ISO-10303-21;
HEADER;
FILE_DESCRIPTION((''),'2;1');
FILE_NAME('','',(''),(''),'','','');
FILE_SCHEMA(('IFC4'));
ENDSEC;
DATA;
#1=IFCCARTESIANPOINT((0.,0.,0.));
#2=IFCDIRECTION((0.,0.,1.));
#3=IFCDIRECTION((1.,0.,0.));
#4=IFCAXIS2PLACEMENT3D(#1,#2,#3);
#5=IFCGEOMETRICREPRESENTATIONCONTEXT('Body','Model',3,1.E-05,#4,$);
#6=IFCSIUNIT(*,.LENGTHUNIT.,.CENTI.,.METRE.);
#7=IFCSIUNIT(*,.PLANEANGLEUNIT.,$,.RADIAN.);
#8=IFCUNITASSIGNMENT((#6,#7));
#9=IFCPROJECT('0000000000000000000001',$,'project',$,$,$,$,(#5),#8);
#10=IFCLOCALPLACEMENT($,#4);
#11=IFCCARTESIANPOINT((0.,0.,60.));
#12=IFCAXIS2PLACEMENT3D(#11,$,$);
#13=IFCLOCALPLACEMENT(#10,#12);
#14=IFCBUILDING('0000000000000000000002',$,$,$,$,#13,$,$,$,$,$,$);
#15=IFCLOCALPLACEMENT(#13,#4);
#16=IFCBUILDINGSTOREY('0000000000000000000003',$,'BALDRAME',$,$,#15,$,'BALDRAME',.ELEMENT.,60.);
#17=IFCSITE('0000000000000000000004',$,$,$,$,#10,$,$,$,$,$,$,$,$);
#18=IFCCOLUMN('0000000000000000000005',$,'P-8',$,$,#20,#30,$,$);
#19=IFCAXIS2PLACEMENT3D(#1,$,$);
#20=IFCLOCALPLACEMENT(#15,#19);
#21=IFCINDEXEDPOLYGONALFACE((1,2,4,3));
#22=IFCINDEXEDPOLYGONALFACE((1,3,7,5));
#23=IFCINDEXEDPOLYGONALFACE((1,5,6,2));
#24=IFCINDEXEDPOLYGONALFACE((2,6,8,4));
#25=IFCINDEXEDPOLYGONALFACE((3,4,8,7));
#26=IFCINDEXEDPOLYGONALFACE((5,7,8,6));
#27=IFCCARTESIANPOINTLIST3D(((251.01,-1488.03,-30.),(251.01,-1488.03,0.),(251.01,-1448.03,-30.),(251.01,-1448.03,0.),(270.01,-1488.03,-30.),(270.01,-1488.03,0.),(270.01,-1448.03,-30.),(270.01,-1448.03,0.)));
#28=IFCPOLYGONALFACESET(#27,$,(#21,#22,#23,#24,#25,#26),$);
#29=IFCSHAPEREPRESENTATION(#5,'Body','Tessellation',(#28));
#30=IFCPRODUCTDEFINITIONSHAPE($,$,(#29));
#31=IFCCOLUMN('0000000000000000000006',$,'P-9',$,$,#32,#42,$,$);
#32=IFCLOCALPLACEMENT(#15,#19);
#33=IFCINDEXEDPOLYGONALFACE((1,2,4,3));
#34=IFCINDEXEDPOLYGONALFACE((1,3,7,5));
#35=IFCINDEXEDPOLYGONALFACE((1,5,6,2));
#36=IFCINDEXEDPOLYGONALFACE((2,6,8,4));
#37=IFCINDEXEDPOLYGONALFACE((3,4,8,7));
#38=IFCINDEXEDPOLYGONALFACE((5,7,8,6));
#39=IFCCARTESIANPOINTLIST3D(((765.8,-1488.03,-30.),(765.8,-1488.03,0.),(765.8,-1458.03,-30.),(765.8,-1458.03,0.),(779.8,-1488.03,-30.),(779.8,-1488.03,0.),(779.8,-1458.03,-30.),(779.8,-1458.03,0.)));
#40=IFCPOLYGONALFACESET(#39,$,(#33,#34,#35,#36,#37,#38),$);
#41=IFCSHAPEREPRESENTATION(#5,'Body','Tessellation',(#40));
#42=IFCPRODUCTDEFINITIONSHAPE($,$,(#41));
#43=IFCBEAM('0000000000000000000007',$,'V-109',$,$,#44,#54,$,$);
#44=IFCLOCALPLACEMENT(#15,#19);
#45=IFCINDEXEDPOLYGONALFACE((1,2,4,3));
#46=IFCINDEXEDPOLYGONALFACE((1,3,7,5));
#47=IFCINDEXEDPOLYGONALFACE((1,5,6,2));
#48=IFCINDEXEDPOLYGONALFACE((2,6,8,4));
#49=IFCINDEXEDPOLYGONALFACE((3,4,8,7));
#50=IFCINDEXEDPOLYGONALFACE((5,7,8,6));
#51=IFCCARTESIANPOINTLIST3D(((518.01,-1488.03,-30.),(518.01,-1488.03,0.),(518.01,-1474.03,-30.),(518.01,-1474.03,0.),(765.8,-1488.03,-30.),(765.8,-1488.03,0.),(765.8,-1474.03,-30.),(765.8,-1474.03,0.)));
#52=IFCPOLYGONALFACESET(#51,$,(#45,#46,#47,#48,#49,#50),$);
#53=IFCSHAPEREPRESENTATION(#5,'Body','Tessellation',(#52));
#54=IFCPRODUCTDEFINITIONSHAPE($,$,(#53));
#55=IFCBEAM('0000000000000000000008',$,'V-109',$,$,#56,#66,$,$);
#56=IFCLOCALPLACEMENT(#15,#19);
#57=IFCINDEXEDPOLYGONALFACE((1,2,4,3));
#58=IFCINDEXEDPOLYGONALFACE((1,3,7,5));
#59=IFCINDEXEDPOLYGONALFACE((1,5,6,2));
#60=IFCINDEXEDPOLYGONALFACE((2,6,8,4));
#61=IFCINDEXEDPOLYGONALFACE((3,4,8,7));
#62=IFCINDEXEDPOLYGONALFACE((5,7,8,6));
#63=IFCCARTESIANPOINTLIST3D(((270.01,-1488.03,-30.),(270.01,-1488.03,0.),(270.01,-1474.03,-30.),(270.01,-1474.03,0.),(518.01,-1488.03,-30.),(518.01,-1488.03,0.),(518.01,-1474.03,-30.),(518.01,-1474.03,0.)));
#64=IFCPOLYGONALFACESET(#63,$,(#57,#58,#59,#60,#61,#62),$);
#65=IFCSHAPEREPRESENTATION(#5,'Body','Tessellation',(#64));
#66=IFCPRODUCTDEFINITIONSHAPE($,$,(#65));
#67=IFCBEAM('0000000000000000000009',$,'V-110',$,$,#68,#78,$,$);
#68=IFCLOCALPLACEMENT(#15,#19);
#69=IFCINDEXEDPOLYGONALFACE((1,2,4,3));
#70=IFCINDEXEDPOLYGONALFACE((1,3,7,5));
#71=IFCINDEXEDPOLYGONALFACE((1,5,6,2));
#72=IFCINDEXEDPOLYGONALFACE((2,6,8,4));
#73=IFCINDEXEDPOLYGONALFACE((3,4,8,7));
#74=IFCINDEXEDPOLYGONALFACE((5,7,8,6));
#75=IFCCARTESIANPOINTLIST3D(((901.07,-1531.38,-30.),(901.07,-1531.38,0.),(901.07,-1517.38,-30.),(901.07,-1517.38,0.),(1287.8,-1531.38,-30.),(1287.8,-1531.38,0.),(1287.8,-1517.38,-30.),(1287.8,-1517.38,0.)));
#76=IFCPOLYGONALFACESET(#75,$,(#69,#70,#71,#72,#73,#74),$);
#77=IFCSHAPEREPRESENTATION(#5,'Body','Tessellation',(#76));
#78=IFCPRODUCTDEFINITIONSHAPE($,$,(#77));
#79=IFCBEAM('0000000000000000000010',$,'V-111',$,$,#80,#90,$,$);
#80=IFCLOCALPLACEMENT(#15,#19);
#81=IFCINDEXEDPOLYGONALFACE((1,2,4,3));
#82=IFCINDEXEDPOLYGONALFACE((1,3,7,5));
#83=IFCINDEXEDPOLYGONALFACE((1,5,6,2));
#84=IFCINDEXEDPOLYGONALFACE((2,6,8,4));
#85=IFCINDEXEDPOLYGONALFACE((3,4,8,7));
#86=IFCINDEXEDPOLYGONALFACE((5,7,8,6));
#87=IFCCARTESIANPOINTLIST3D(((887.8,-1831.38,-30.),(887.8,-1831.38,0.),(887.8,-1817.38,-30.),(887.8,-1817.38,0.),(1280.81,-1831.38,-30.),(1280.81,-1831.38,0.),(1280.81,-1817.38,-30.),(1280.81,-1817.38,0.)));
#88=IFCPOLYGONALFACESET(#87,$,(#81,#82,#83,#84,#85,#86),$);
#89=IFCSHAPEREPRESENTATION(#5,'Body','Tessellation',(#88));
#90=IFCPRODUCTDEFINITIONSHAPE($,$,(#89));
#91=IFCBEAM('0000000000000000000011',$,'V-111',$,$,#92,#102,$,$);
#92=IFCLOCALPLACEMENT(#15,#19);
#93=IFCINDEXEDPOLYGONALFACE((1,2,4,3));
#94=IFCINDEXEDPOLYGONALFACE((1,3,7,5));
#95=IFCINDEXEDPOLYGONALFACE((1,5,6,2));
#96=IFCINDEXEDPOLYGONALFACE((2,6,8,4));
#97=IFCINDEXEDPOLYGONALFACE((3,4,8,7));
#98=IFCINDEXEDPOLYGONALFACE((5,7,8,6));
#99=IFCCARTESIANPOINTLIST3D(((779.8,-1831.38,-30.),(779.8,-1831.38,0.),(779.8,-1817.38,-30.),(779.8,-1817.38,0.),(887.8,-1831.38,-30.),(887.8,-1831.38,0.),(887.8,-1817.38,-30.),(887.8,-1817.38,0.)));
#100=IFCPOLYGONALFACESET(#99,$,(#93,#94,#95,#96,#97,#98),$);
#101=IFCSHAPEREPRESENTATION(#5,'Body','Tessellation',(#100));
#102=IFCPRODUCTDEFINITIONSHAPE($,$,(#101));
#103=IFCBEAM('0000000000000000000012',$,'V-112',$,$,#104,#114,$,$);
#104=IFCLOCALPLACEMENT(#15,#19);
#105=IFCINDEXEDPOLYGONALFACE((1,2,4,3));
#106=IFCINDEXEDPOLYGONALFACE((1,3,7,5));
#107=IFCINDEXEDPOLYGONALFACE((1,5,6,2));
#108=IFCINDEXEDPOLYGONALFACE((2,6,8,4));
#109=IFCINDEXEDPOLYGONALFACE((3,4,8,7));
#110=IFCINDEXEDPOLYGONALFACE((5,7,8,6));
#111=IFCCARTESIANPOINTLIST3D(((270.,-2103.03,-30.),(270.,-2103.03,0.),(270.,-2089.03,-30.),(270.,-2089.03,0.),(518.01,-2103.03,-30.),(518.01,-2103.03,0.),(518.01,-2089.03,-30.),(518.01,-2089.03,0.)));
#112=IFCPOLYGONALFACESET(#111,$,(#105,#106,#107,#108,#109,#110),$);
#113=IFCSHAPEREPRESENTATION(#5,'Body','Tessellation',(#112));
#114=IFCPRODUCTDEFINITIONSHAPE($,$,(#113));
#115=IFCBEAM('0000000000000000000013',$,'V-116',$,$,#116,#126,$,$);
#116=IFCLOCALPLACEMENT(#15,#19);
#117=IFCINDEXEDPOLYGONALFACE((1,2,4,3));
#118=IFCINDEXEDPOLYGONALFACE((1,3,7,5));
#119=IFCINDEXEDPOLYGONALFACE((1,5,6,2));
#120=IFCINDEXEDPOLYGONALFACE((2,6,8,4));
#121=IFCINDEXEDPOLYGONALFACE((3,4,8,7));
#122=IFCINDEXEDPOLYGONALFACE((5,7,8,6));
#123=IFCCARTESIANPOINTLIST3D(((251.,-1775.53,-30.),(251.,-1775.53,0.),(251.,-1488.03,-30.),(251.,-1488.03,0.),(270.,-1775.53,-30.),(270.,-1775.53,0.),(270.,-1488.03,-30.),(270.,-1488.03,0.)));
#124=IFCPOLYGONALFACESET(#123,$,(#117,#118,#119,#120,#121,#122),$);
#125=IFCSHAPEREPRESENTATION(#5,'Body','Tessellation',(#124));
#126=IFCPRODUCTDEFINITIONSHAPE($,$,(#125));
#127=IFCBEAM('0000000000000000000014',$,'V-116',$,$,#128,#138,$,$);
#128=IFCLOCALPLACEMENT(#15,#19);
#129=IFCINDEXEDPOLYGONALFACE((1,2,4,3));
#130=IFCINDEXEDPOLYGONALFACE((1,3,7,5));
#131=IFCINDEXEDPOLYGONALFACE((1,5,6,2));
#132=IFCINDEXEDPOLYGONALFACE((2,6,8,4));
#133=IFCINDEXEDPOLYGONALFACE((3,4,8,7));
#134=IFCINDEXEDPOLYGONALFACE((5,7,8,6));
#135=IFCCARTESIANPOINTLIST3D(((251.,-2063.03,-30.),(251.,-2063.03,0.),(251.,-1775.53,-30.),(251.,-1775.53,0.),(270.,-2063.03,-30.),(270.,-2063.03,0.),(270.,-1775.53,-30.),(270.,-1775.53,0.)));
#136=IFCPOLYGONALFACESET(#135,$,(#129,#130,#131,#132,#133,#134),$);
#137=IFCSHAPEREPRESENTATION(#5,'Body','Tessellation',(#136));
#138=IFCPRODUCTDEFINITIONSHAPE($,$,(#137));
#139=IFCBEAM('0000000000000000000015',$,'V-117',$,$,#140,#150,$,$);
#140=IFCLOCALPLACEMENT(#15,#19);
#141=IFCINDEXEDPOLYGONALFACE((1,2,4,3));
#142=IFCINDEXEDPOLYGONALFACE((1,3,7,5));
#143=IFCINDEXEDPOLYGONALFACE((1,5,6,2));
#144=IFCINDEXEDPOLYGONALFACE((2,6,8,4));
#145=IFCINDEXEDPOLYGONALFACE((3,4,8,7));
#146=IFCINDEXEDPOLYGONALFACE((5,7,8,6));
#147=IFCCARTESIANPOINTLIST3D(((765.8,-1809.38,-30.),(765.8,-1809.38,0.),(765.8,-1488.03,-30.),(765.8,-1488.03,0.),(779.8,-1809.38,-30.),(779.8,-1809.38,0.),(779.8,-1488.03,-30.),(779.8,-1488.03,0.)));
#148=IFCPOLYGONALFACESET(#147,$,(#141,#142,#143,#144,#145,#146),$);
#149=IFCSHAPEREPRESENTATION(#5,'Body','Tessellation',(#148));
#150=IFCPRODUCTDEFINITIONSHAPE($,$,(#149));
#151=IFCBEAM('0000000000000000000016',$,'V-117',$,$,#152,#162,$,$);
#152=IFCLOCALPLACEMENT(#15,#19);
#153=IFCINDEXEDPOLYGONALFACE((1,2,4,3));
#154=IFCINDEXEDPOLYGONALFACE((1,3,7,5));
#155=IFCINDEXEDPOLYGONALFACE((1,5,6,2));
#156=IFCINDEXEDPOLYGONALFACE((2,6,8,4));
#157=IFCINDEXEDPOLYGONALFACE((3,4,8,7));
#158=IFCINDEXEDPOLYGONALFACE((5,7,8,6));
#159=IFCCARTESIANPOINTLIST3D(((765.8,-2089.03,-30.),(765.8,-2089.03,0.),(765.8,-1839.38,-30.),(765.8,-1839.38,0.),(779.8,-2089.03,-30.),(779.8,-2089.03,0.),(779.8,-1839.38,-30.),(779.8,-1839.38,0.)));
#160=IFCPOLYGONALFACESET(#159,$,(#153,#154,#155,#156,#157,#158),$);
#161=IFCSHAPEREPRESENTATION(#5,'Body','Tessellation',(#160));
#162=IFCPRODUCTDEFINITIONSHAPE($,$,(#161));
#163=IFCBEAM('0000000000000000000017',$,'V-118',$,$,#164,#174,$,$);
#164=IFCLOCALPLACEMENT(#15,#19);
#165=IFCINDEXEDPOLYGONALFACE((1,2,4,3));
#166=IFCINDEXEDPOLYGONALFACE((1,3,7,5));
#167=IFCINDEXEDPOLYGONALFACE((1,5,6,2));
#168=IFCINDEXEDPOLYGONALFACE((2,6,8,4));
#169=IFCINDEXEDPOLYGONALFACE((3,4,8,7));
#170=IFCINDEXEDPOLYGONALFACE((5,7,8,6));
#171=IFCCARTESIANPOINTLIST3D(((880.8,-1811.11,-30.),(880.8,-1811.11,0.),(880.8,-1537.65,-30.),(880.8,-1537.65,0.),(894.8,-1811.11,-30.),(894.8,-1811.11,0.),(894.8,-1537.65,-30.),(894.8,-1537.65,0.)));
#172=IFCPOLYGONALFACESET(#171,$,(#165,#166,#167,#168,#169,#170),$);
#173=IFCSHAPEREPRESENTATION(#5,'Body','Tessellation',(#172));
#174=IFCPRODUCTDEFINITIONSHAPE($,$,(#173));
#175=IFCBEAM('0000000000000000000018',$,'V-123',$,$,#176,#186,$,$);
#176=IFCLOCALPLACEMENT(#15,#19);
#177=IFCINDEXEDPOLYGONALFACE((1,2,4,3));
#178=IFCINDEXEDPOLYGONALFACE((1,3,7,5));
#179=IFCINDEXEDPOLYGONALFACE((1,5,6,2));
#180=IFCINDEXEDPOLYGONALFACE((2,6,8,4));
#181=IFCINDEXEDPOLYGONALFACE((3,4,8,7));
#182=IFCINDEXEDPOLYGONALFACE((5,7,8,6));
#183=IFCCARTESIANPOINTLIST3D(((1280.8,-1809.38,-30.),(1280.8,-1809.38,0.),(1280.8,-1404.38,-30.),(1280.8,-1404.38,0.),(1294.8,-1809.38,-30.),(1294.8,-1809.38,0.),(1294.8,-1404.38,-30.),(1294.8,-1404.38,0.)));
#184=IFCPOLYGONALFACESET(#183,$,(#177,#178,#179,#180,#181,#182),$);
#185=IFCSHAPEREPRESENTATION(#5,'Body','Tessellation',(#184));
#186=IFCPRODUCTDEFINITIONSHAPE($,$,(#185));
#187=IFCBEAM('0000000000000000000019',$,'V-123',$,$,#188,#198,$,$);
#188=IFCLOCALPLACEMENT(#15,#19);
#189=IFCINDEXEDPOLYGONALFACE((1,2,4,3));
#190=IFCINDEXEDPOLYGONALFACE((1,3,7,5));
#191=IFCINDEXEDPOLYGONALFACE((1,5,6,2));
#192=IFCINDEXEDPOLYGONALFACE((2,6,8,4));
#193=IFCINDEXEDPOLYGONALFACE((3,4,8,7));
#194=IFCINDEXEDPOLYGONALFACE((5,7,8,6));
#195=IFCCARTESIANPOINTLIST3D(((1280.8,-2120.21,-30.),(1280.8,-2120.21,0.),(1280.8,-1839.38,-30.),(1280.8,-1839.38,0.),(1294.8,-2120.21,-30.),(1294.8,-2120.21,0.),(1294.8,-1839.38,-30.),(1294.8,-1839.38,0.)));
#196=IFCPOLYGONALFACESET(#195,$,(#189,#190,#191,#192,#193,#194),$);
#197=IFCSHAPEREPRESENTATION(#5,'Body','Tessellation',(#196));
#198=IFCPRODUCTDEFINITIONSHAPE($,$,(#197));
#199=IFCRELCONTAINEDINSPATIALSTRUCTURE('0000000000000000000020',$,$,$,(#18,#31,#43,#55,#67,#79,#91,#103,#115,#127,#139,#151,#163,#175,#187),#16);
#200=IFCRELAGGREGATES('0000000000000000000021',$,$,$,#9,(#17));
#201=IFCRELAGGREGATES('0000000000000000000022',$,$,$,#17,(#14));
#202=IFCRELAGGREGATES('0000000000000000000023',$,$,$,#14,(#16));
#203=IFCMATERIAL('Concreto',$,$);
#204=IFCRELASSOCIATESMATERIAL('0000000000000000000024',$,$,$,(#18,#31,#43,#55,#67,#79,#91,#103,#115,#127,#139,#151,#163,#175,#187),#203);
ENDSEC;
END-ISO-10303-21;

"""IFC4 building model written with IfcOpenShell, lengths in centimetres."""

from ifc_helpers import new_model, si_unit, frame, origin_with_axes, origin_2d_with_axis, place, context, project, spatial, rectangle, extrude, material, element, save


model = new_model("IFC4")

# Units and contexts
model_context = context("Model", 3, precision=1e-05, world=origin_with_axes(), identifier="Body")
ifc_project = project(units=[si_unit("LENGTHUNIT", "METRE", prefix="CENTI"), si_unit("PLANEANGLEUNIT", "RADIAN")], contexts=[model_context])

# Site, building, storey
site_placement = place(None, origin_with_axes())
site = spatial("IfcSite", under=ifc_project, at=site_placement)
building_placement = place(site_placement, frame((0.0, 0.0, 60.0)))
building = spatial("IfcBuilding", under=site, at=building_placement)
storey_placement = place(building_placement, origin_with_axes())
storey = spatial("IfcBuildingStorey", under=building, at=storey_placement, Name="BALDRAME", LongName="BALDRAME", CompositionType="ELEMENT", Elevation=60.0)

# Shared definitions
ifc_material = material(Name="Concreto")

# Columns
for number, where, z_axis, x_axis, name in (
    (1, (260.51, -1468.03, 0.0), (0.0, 0.0, 1.0), (1.0, 0.0, 0.0), "P-8"),
):
    element("IfcColumn", number, at=place(storey_placement, frame(where, z_axis=z_axis, x_axis=x_axis)), inside=storey, material=ifc_material, Name=name, context=model_context, shape_type="SolidModel", body=[
        extrude(rectangle(XDim=19.0, YDim=40.0, at=origin_2d_with_axis()), frame((0.0, 0.0, -30.0), z_axis=(0.0, 0.0, 1.0), x_axis=(1.0, 0.0, 0.0)), (0.0, 0.0, 1.0), 30.0),
    ])
column_placement = place(storey_placement, frame((772.8, -1473.03, 0.0), z_axis=(0.0, 0.0, 1.0), x_axis=(1.0, 0.0, 0.0)))
element("IfcColumn", 2, at=column_placement, inside=storey, material=ifc_material, Name="P-9", context=model_context, shape_type="SolidModel", body=[
    extrude(rectangle(XDim=14.0, YDim=30.0, at=origin_2d_with_axis()), frame((0.0, 0.0, -30.0), z_axis=(0.0, 0.0, 1.0), x_axis=(1.0, 0.0, 0.0)), (0.0, 0.0, 1.0), 30.0),
])

# Beams
beam_1_placement = place(storey_placement, frame((641.9, -1481.03, 0.0), z_axis=(0.0, 0.0, 1.0), x_axis=(1.0, 0.0, 0.0)))
element("IfcBeam", 3, at=beam_1_placement, inside=storey, material=ifc_material, Name="V-109", context=model_context, shape_type="SolidModel", body=[
    extrude(rectangle(XDim=14.0, YDim=30.0, at=origin_2d_with_axis()), frame((-123.89, 0.0, -15.0), z_axis=(1.0, 0.0, 0.0), x_axis=(0.0, -1.0, 0.0)), (0.0, 0.0, 1.0), 247.79),
])
beam_2_placement = place(storey_placement, frame((394.01, -1481.03, 0.0), z_axis=(0.0, 0.0, 1.0), x_axis=(1.0, 0.0, 0.0)))
element("IfcBeam", 4, at=beam_2_placement, inside=storey, material=ifc_material, Name="V-109", context=model_context, shape_type="SolidModel", body=[
    extrude(rectangle(XDim=14.0, YDim=30.0, at=origin_2d_with_axis()), frame((-124.0, 0.0, -15.0), z_axis=(1.0, 0.0, 0.0), x_axis=(0.0, -1.0, 0.0)), (0.0, 0.0, 1.0), 248.0),
])
beam_3_placement = place(storey_placement, frame((1094.43, -1524.38, 0.0), z_axis=(0.0, 0.0, 1.0), x_axis=(1.0, 0.0, 0.0)))
element("IfcBeam", 5, at=beam_3_placement, inside=storey, material=ifc_material, Name="V-110", context=model_context, shape_type="SolidModel", body=[
    extrude(rectangle(XDim=14.0, YDim=30.0, at=origin_2d_with_axis()), frame((-193.37, 0.0, -15.0), z_axis=(1.0, 0.0, 0.0), x_axis=(0.0, -1.0, 0.0)), (0.0, 0.0, 1.0), 386.73),
])
beam_4_placement = place(storey_placement, frame((1084.31, -1824.38, 0.0), z_axis=(0.0, 0.0, 1.0), x_axis=(1.0, 0.0, 0.0)))
element("IfcBeam", 6, at=beam_4_placement, inside=storey, material=ifc_material, Name="V-111", context=model_context, shape_type="SolidModel", body=[
    extrude(rectangle(XDim=14.0, YDim=30.0, at=origin_2d_with_axis()), frame((-196.5, 0.0, -15.0), z_axis=(1.0, 0.0, 0.0), x_axis=(0.0, -1.0, 0.0)), (0.0, 0.0, 1.0), 393.01),
])
beam_5_placement = place(storey_placement, frame((833.8, -1824.38, 0.0), z_axis=(0.0, 0.0, 1.0), x_axis=(1.0, 0.0, 0.0)))
element("IfcBeam", 7, at=beam_5_placement, inside=storey, material=ifc_material, Name="V-111", context=model_context, shape_type="SolidModel", body=[
    extrude(rectangle(XDim=14.0, YDim=30.0, at=origin_2d_with_axis()), frame((-54.0, 0.0, -15.0), z_axis=(1.0, 0.0, 0.0), x_axis=(0.0, -1.0, 0.0)), (0.0, 0.0, 1.0), 108.0),
])
beam_6_placement = place(storey_placement, frame((394.0, -2096.03, 0.0), z_axis=(0.0, 0.0, 1.0), x_axis=(1.0, 0.0, 0.0)))
element("IfcBeam", 8, at=beam_6_placement, inside=storey, material=ifc_material, Name="V-112", context=model_context, shape_type="SolidModel", body=[
    extrude(rectangle(XDim=14.0, YDim=30.0, at=origin_2d_with_axis()), frame((-124.0, 0.0, -15.0), z_axis=(1.0, 0.0, 0.0), x_axis=(0.0, -1.0, 0.0)), (0.0, 0.0, 1.0), 248.01),
])
for number, where, z_axis, x_axis, name in (
    (9, (260.5, -1631.78, 0.0), (0.0, 0.0, 1.0), (1.0, 0.0, 0.0), "V-116"),
    (10, (260.5, -1919.28, 0.0), (0.0, 0.0, 1.0), (1.0, 0.0, 0.0), "V-116"),
):
    element("IfcBeam", number, at=place(storey_placement, frame(where, z_axis=z_axis, x_axis=x_axis)), inside=storey, material=ifc_material, Name=name, context=model_context, shape_type="SolidModel", body=[
        extrude(rectangle(XDim=19.0, YDim=30.0, at=origin_2d_with_axis()), frame((0.0, -143.75, -15.0), z_axis=(0.0, 1.0, 0.0), x_axis=(1.0, 0.0, 0.0)), (0.0, 0.0, 1.0), 287.5),
    ])
beam_7_placement = place(storey_placement, frame((772.8, -1648.7, 0.0), z_axis=(0.0, 0.0, 1.0), x_axis=(1.0, 0.0, 0.0)))
element("IfcBeam", 11, at=beam_7_placement, inside=storey, material=ifc_material, Name="V-117", context=model_context, shape_type="SolidModel", body=[
    extrude(rectangle(XDim=14.0, YDim=30.0, at=origin_2d_with_axis()), frame((0.0, -160.68, -15.0), z_axis=(0.0, 1.0, 0.0), x_axis=(1.0, 0.0, 0.0)), (0.0, 0.0, 1.0), 321.35),
])
beam_8_placement = place(storey_placement, frame((772.8, -1964.2, 0.0), z_axis=(0.0, 0.0, 1.0), x_axis=(1.0, 0.0, 0.0)))
element("IfcBeam", 12, at=beam_8_placement, inside=storey, material=ifc_material, Name="V-117", context=model_context, shape_type="SolidModel", body=[
    extrude(rectangle(XDim=14.0, YDim=30.0, at=origin_2d_with_axis()), frame((0.0, -124.83, -15.0), z_axis=(0.0, 1.0, 0.0), x_axis=(1.0, 0.0, 0.0)), (0.0, 0.0, 1.0), 249.65),
])
beam_9_placement = place(storey_placement, frame((887.8, -1674.38, 0.0), z_axis=(0.0, 0.0, 1.0), x_axis=(1.0, 0.0, 0.0)))
element("IfcBeam", 13, at=beam_9_placement, inside=storey, material=ifc_material, Name="V-118", context=model_context, shape_type="SolidModel", body=[
    extrude(rectangle(XDim=14.0, YDim=30.0, at=origin_2d_with_axis()), frame((0.0, -136.73, -15.0), z_axis=(0.0, 1.0, 0.0), x_axis=(1.0, 0.0, 0.0)), (0.0, 0.0, 1.0), 273.47),
])
beam_10_placement = place(storey_placement, frame((1287.8, -1606.88, 0.0), z_axis=(0.0, 0.0, 1.0), x_axis=(1.0, 0.0, 0.0)))
element("IfcBeam", 14, at=beam_10_placement, inside=storey, material=ifc_material, Name="V-123", context=model_context, shape_type="SolidModel", body=[
    extrude(rectangle(XDim=14.0, YDim=30.0, at=origin_2d_with_axis()), frame((0.0, -202.5, -15.0), z_axis=(0.0, 1.0, 0.0), x_axis=(1.0, 0.0, 0.0)), (0.0, 0.0, 1.0), 405.0),
])
beam_11_placement = place(storey_placement, frame((1287.8, -1979.8, 0.0), z_axis=(0.0, 0.0, 1.0), x_axis=(1.0, 0.0, 0.0)))
element("IfcBeam", 15, at=beam_11_placement, inside=storey, material=ifc_material, Name="V-123", context=model_context, shape_type="SolidModel", body=[
    extrude(rectangle(XDim=14.0, YDim=30.0, at=origin_2d_with_axis()), frame((0.0, -140.41, -15.0), z_axis=(0.0, 1.0, 0.0), x_axis=(1.0, 0.0, 0.0)), (0.0, 0.0, 1.0), 280.83),
])

save(model, "model.ifc")
